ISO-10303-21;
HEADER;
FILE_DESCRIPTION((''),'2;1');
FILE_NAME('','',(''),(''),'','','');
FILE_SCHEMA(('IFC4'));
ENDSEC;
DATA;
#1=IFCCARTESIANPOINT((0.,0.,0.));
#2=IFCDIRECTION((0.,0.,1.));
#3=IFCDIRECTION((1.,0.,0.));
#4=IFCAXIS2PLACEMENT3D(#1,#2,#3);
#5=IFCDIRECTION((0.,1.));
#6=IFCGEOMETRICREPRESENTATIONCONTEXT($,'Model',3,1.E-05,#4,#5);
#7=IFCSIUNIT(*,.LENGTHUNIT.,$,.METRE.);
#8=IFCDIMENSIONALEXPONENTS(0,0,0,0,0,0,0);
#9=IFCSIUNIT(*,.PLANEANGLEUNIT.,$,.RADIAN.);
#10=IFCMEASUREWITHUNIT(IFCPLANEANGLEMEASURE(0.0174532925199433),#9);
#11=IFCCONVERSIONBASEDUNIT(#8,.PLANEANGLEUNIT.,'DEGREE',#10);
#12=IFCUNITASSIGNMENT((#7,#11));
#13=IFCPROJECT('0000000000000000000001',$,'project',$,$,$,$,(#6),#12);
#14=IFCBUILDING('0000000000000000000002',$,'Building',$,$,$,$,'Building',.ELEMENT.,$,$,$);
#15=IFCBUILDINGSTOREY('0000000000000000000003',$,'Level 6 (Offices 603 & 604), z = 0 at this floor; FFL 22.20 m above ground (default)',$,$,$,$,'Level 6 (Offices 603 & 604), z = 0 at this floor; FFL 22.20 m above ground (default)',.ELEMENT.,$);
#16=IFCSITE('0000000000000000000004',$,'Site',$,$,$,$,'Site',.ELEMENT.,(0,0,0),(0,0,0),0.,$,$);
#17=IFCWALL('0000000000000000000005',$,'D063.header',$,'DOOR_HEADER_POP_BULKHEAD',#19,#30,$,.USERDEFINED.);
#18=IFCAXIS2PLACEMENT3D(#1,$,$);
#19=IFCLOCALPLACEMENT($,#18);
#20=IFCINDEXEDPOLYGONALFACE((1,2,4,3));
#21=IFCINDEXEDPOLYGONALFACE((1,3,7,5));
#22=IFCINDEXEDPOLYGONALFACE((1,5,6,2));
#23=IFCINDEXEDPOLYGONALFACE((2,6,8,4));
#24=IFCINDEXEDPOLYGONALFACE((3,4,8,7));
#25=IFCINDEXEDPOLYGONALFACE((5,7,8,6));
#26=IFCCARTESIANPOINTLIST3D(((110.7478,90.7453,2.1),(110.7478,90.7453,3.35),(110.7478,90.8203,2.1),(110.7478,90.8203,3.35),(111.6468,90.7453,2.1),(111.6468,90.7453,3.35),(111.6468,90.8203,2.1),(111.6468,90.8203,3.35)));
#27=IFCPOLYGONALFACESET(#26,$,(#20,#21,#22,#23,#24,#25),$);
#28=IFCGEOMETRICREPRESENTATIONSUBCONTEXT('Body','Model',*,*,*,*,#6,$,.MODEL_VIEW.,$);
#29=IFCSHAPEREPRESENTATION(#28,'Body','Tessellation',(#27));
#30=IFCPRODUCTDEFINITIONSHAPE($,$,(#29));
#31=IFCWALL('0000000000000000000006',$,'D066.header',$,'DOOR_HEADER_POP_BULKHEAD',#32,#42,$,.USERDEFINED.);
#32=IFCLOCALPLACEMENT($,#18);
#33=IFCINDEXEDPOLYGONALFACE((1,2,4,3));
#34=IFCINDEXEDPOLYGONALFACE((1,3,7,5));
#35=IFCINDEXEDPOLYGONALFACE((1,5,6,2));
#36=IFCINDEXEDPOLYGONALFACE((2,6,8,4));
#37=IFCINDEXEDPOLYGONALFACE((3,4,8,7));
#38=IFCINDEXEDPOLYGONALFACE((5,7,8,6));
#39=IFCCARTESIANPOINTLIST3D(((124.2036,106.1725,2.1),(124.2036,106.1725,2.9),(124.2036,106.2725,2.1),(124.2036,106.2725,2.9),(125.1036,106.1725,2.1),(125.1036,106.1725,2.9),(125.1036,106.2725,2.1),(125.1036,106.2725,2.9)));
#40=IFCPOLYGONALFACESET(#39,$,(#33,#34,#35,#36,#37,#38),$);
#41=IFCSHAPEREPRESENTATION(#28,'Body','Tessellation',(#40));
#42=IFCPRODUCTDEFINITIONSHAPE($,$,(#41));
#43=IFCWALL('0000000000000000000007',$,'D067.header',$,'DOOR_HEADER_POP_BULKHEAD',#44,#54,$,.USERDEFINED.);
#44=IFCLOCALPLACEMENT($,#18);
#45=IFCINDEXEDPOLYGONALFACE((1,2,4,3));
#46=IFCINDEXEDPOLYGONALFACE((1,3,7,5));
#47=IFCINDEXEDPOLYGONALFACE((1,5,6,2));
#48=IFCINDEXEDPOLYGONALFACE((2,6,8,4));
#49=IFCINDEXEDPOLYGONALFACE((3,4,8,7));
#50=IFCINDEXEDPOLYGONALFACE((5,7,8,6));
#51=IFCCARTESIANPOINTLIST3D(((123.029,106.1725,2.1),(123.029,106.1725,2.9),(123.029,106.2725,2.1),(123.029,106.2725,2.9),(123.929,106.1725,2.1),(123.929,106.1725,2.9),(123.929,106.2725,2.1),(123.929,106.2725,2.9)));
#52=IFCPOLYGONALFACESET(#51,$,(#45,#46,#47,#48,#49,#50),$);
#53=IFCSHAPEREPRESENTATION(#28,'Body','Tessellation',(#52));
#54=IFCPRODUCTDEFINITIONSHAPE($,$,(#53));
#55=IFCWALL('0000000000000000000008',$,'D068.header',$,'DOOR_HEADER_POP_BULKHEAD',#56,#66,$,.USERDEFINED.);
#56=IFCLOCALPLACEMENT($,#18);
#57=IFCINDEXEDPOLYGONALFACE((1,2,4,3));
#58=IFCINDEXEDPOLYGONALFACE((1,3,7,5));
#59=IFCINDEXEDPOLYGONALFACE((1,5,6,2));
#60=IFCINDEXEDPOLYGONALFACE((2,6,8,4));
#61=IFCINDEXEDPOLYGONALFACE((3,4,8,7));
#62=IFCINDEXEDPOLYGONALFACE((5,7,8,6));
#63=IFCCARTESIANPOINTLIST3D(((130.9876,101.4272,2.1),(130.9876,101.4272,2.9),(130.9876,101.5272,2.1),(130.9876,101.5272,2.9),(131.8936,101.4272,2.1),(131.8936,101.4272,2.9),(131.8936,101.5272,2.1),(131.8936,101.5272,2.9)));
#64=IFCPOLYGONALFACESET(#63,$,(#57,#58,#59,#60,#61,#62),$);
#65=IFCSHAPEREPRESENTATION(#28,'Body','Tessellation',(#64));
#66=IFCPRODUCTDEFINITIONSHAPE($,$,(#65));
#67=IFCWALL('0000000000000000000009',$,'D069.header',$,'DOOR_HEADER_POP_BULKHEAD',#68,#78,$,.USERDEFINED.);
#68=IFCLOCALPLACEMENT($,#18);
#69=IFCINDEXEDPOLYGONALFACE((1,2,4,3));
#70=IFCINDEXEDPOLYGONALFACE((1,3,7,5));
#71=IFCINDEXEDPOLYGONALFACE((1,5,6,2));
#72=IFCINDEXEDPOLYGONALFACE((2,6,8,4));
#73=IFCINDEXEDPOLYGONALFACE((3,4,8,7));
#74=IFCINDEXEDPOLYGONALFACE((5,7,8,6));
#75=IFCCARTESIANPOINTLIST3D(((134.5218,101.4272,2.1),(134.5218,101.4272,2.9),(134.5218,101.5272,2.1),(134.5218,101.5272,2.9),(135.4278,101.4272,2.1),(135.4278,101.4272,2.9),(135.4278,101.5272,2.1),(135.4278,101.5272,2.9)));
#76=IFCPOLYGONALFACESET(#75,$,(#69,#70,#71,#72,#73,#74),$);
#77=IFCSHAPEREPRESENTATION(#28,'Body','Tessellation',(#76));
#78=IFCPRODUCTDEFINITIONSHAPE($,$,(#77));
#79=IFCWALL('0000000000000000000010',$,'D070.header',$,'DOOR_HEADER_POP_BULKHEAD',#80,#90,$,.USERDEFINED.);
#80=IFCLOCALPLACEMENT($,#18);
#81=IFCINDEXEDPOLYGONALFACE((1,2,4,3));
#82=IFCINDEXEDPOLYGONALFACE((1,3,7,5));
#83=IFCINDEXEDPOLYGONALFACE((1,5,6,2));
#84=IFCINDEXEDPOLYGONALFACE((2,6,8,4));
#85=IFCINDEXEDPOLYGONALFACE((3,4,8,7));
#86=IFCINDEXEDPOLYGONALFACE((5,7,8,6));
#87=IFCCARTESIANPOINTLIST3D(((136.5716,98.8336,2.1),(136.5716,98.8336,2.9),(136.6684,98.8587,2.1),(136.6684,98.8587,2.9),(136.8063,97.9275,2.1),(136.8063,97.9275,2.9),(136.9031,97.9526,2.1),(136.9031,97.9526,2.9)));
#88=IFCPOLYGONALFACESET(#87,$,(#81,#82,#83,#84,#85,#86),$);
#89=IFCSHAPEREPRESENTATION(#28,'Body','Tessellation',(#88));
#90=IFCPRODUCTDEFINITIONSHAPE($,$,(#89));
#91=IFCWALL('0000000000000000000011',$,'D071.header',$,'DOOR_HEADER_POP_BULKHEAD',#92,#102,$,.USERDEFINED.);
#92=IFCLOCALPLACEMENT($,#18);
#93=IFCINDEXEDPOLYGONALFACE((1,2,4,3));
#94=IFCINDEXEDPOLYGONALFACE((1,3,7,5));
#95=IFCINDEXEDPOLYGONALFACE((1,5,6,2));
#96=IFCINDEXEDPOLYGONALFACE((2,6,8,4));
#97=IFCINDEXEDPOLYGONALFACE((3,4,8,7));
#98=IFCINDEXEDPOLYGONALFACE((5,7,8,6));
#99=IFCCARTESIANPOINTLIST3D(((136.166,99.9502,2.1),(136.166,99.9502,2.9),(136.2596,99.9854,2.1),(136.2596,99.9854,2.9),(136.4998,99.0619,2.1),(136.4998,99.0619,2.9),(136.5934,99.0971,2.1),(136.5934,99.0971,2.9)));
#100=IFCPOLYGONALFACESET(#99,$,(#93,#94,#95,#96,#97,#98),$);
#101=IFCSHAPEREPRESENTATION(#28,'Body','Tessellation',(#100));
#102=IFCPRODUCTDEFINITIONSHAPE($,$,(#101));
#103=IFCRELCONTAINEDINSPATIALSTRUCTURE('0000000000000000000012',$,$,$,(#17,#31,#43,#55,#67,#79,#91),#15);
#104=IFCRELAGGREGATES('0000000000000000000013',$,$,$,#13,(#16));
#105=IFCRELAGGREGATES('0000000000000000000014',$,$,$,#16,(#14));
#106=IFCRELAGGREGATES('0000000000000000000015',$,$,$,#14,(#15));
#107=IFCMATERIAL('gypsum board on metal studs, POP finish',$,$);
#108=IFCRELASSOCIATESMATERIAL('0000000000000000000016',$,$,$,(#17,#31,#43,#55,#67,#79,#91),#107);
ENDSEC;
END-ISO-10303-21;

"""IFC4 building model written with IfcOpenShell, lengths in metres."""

from ifc_helpers import new_model, entity, si_unit, converted_unit, direction, frame, frame_2d, origin_with_axes, origin_2d_with_axis, place, context, subcontext, project, spatial, rectangle, extrude, material, element, save


model = new_model("IFC4")

# Units and contexts
model_context = context("Model", 3, precision=1e-05, world=origin_with_axes(), true_north=direction((0.0, 1.0)))
body_context = subcontext(model_context, "Body", "Model", "MODEL_VIEW")
ifc_project = project(units=[si_unit("LENGTHUNIT", "METRE"), converted_unit("PLANEANGLEUNIT", "DEGREE", entity("IfcPlaneAngleMeasure", 0.0174532925199433), si_unit("PLANEANGLEUNIT", "RADIAN"), dimensions=[0, 0, 0, 0, 0, 0, 0])], contexts=[model_context])

# Site, building, storey
site = spatial("IfcSite", under=ifc_project, Name="Site", LongName="Site", CompositionType="ELEMENT", RefLatitude=(0, 0, 0), RefLongitude=(0, 0, 0), RefElevation=0.0)
building = spatial("IfcBuilding", under=site, Name="Building", LongName="Building", CompositionType="ELEMENT")
storey = spatial("IfcBuildingStorey", under=building, Name="Level 6 (Offices 603 & 604), z = 0 at this floor; FFL 22.20 m above ground (default)", LongName="Level 6 (Offices 603 & 604), z = 0 at this floor; FFL 22.20 m above ground (default)", CompositionType="ELEMENT")

# Shared definitions
placement = place(None, origin_with_axes())

# Walls
ifc_material_1 = material(Name="gypsum board on metal studs, POP finish")
element("IfcWall", 1, at=placement, inside=storey, material=ifc_material_1, Name="D063.header", ObjectType="DOOR_HEADER_POP_BULKHEAD", PredefinedType="USERDEFINED", context=body_context, shape_type="SweptSolid", body=[
    extrude(rectangle(XDim=0.899, YDim=0.075, at=frame_2d((0.0, 0.0), x_axis=(1.0, 0.0))), frame((111.1973, 90.7828, 2.1), z_axis=(0.0, 0.0, 1.0), x_axis=(1.0, 0.0, 0.0)), (0.0, 0.0, 1.0), 1.25),
])
element("IfcWall", 2, at=placement, inside=storey, material=ifc_material_1, Name="D066.header", ObjectType="DOOR_HEADER_POP_BULKHEAD", PredefinedType="USERDEFINED", context=body_context, shape_type="SweptSolid", body=[
    extrude(rectangle(XDim=0.9, YDim=0.1, at=origin_2d_with_axis()), frame((124.6536, 106.2225, 2.1), z_axis=(0.0, 0.0, 1.0), x_axis=(1.0, 0.0, 0.0)), (0.0, 0.0, 1.0), 0.8),
])
element("IfcWall", 3, at=placement, inside=storey, material=ifc_material_1, Name="D067.header", ObjectType="DOOR_HEADER_POP_BULKHEAD", PredefinedType="USERDEFINED", context=body_context, shape_type="SweptSolid", body=[
    extrude(rectangle(XDim=0.9, YDim=0.1, at=origin_2d_with_axis()), frame((123.479, 106.2225, 2.1), z_axis=(0.0, 0.0, 1.0), x_axis=(1.0, 0.0, 0.0)), (0.0, 0.0, 1.0), 0.8),
])
element("IfcWall", 4, at=placement, inside=storey, material=ifc_material_1, Name="D068.header", ObjectType="DOOR_HEADER_POP_BULKHEAD", PredefinedType="USERDEFINED", context=body_context, shape_type="SweptSolid", body=[
    extrude(rectangle(XDim=0.906, YDim=0.1, at=origin_2d_with_axis()), frame((131.4407, 101.4772, 2.1), z_axis=(0.0, 0.0, 1.0), x_axis=(1.0, 0.0, 0.0)), (0.0, 0.0, 1.0), 0.8),
])
element("IfcWall", 5, at=placement, inside=storey, material=ifc_material_1, Name="D069.header", ObjectType="DOOR_HEADER_POP_BULKHEAD", PredefinedType="USERDEFINED", context=body_context, shape_type="SweptSolid", body=[
    extrude(rectangle(XDim=0.906, YDim=0.1, at=origin_2d_with_axis()), frame((134.9749, 101.4772, 2.1), z_axis=(0.0, 0.0, 1.0), x_axis=(1.0, 0.0, 0.0)), (0.0, 0.0, 1.0), 0.8),
])
element("IfcWall", 6, at=placement, inside=storey, material=ifc_material_1, Name="D070.header", ObjectType="DOOR_HEADER_POP_BULKHEAD", PredefinedType="USERDEFINED", context=body_context, shape_type="SweptSolid", body=[
    extrude(rectangle(XDim=0.936, YDim=0.1, at=frame_2d((0.0, 0.0), x_axis=(0.250669, -0.968073))), frame((136.7373, 98.3931, 2.1), z_axis=(0.0, 0.0, 1.0), x_axis=(1.0, 0.0, 0.0)), (0.0, 0.0, 1.0), 0.8),
])
element("IfcWall", 7, at=placement, inside=storey, material=ifc_material_1, Name="D071.header", ObjectType="DOOR_HEADER_POP_BULKHEAD", PredefinedType="USERDEFINED", context=body_context, shape_type="SweptSolid", body=[
    extrude(rectangle(XDim=0.949, YDim=0.1, at=frame_2d((0.0, 0.0), x_axis=(0.351804, -0.936074))), frame((136.3797, 99.5237, 2.1), z_axis=(0.0, 0.0, 1.0), x_axis=(1.0, 0.0, 0.0)), (0.0, 0.0, 1.0), 0.8),
])

save(model, "model.ifc")
